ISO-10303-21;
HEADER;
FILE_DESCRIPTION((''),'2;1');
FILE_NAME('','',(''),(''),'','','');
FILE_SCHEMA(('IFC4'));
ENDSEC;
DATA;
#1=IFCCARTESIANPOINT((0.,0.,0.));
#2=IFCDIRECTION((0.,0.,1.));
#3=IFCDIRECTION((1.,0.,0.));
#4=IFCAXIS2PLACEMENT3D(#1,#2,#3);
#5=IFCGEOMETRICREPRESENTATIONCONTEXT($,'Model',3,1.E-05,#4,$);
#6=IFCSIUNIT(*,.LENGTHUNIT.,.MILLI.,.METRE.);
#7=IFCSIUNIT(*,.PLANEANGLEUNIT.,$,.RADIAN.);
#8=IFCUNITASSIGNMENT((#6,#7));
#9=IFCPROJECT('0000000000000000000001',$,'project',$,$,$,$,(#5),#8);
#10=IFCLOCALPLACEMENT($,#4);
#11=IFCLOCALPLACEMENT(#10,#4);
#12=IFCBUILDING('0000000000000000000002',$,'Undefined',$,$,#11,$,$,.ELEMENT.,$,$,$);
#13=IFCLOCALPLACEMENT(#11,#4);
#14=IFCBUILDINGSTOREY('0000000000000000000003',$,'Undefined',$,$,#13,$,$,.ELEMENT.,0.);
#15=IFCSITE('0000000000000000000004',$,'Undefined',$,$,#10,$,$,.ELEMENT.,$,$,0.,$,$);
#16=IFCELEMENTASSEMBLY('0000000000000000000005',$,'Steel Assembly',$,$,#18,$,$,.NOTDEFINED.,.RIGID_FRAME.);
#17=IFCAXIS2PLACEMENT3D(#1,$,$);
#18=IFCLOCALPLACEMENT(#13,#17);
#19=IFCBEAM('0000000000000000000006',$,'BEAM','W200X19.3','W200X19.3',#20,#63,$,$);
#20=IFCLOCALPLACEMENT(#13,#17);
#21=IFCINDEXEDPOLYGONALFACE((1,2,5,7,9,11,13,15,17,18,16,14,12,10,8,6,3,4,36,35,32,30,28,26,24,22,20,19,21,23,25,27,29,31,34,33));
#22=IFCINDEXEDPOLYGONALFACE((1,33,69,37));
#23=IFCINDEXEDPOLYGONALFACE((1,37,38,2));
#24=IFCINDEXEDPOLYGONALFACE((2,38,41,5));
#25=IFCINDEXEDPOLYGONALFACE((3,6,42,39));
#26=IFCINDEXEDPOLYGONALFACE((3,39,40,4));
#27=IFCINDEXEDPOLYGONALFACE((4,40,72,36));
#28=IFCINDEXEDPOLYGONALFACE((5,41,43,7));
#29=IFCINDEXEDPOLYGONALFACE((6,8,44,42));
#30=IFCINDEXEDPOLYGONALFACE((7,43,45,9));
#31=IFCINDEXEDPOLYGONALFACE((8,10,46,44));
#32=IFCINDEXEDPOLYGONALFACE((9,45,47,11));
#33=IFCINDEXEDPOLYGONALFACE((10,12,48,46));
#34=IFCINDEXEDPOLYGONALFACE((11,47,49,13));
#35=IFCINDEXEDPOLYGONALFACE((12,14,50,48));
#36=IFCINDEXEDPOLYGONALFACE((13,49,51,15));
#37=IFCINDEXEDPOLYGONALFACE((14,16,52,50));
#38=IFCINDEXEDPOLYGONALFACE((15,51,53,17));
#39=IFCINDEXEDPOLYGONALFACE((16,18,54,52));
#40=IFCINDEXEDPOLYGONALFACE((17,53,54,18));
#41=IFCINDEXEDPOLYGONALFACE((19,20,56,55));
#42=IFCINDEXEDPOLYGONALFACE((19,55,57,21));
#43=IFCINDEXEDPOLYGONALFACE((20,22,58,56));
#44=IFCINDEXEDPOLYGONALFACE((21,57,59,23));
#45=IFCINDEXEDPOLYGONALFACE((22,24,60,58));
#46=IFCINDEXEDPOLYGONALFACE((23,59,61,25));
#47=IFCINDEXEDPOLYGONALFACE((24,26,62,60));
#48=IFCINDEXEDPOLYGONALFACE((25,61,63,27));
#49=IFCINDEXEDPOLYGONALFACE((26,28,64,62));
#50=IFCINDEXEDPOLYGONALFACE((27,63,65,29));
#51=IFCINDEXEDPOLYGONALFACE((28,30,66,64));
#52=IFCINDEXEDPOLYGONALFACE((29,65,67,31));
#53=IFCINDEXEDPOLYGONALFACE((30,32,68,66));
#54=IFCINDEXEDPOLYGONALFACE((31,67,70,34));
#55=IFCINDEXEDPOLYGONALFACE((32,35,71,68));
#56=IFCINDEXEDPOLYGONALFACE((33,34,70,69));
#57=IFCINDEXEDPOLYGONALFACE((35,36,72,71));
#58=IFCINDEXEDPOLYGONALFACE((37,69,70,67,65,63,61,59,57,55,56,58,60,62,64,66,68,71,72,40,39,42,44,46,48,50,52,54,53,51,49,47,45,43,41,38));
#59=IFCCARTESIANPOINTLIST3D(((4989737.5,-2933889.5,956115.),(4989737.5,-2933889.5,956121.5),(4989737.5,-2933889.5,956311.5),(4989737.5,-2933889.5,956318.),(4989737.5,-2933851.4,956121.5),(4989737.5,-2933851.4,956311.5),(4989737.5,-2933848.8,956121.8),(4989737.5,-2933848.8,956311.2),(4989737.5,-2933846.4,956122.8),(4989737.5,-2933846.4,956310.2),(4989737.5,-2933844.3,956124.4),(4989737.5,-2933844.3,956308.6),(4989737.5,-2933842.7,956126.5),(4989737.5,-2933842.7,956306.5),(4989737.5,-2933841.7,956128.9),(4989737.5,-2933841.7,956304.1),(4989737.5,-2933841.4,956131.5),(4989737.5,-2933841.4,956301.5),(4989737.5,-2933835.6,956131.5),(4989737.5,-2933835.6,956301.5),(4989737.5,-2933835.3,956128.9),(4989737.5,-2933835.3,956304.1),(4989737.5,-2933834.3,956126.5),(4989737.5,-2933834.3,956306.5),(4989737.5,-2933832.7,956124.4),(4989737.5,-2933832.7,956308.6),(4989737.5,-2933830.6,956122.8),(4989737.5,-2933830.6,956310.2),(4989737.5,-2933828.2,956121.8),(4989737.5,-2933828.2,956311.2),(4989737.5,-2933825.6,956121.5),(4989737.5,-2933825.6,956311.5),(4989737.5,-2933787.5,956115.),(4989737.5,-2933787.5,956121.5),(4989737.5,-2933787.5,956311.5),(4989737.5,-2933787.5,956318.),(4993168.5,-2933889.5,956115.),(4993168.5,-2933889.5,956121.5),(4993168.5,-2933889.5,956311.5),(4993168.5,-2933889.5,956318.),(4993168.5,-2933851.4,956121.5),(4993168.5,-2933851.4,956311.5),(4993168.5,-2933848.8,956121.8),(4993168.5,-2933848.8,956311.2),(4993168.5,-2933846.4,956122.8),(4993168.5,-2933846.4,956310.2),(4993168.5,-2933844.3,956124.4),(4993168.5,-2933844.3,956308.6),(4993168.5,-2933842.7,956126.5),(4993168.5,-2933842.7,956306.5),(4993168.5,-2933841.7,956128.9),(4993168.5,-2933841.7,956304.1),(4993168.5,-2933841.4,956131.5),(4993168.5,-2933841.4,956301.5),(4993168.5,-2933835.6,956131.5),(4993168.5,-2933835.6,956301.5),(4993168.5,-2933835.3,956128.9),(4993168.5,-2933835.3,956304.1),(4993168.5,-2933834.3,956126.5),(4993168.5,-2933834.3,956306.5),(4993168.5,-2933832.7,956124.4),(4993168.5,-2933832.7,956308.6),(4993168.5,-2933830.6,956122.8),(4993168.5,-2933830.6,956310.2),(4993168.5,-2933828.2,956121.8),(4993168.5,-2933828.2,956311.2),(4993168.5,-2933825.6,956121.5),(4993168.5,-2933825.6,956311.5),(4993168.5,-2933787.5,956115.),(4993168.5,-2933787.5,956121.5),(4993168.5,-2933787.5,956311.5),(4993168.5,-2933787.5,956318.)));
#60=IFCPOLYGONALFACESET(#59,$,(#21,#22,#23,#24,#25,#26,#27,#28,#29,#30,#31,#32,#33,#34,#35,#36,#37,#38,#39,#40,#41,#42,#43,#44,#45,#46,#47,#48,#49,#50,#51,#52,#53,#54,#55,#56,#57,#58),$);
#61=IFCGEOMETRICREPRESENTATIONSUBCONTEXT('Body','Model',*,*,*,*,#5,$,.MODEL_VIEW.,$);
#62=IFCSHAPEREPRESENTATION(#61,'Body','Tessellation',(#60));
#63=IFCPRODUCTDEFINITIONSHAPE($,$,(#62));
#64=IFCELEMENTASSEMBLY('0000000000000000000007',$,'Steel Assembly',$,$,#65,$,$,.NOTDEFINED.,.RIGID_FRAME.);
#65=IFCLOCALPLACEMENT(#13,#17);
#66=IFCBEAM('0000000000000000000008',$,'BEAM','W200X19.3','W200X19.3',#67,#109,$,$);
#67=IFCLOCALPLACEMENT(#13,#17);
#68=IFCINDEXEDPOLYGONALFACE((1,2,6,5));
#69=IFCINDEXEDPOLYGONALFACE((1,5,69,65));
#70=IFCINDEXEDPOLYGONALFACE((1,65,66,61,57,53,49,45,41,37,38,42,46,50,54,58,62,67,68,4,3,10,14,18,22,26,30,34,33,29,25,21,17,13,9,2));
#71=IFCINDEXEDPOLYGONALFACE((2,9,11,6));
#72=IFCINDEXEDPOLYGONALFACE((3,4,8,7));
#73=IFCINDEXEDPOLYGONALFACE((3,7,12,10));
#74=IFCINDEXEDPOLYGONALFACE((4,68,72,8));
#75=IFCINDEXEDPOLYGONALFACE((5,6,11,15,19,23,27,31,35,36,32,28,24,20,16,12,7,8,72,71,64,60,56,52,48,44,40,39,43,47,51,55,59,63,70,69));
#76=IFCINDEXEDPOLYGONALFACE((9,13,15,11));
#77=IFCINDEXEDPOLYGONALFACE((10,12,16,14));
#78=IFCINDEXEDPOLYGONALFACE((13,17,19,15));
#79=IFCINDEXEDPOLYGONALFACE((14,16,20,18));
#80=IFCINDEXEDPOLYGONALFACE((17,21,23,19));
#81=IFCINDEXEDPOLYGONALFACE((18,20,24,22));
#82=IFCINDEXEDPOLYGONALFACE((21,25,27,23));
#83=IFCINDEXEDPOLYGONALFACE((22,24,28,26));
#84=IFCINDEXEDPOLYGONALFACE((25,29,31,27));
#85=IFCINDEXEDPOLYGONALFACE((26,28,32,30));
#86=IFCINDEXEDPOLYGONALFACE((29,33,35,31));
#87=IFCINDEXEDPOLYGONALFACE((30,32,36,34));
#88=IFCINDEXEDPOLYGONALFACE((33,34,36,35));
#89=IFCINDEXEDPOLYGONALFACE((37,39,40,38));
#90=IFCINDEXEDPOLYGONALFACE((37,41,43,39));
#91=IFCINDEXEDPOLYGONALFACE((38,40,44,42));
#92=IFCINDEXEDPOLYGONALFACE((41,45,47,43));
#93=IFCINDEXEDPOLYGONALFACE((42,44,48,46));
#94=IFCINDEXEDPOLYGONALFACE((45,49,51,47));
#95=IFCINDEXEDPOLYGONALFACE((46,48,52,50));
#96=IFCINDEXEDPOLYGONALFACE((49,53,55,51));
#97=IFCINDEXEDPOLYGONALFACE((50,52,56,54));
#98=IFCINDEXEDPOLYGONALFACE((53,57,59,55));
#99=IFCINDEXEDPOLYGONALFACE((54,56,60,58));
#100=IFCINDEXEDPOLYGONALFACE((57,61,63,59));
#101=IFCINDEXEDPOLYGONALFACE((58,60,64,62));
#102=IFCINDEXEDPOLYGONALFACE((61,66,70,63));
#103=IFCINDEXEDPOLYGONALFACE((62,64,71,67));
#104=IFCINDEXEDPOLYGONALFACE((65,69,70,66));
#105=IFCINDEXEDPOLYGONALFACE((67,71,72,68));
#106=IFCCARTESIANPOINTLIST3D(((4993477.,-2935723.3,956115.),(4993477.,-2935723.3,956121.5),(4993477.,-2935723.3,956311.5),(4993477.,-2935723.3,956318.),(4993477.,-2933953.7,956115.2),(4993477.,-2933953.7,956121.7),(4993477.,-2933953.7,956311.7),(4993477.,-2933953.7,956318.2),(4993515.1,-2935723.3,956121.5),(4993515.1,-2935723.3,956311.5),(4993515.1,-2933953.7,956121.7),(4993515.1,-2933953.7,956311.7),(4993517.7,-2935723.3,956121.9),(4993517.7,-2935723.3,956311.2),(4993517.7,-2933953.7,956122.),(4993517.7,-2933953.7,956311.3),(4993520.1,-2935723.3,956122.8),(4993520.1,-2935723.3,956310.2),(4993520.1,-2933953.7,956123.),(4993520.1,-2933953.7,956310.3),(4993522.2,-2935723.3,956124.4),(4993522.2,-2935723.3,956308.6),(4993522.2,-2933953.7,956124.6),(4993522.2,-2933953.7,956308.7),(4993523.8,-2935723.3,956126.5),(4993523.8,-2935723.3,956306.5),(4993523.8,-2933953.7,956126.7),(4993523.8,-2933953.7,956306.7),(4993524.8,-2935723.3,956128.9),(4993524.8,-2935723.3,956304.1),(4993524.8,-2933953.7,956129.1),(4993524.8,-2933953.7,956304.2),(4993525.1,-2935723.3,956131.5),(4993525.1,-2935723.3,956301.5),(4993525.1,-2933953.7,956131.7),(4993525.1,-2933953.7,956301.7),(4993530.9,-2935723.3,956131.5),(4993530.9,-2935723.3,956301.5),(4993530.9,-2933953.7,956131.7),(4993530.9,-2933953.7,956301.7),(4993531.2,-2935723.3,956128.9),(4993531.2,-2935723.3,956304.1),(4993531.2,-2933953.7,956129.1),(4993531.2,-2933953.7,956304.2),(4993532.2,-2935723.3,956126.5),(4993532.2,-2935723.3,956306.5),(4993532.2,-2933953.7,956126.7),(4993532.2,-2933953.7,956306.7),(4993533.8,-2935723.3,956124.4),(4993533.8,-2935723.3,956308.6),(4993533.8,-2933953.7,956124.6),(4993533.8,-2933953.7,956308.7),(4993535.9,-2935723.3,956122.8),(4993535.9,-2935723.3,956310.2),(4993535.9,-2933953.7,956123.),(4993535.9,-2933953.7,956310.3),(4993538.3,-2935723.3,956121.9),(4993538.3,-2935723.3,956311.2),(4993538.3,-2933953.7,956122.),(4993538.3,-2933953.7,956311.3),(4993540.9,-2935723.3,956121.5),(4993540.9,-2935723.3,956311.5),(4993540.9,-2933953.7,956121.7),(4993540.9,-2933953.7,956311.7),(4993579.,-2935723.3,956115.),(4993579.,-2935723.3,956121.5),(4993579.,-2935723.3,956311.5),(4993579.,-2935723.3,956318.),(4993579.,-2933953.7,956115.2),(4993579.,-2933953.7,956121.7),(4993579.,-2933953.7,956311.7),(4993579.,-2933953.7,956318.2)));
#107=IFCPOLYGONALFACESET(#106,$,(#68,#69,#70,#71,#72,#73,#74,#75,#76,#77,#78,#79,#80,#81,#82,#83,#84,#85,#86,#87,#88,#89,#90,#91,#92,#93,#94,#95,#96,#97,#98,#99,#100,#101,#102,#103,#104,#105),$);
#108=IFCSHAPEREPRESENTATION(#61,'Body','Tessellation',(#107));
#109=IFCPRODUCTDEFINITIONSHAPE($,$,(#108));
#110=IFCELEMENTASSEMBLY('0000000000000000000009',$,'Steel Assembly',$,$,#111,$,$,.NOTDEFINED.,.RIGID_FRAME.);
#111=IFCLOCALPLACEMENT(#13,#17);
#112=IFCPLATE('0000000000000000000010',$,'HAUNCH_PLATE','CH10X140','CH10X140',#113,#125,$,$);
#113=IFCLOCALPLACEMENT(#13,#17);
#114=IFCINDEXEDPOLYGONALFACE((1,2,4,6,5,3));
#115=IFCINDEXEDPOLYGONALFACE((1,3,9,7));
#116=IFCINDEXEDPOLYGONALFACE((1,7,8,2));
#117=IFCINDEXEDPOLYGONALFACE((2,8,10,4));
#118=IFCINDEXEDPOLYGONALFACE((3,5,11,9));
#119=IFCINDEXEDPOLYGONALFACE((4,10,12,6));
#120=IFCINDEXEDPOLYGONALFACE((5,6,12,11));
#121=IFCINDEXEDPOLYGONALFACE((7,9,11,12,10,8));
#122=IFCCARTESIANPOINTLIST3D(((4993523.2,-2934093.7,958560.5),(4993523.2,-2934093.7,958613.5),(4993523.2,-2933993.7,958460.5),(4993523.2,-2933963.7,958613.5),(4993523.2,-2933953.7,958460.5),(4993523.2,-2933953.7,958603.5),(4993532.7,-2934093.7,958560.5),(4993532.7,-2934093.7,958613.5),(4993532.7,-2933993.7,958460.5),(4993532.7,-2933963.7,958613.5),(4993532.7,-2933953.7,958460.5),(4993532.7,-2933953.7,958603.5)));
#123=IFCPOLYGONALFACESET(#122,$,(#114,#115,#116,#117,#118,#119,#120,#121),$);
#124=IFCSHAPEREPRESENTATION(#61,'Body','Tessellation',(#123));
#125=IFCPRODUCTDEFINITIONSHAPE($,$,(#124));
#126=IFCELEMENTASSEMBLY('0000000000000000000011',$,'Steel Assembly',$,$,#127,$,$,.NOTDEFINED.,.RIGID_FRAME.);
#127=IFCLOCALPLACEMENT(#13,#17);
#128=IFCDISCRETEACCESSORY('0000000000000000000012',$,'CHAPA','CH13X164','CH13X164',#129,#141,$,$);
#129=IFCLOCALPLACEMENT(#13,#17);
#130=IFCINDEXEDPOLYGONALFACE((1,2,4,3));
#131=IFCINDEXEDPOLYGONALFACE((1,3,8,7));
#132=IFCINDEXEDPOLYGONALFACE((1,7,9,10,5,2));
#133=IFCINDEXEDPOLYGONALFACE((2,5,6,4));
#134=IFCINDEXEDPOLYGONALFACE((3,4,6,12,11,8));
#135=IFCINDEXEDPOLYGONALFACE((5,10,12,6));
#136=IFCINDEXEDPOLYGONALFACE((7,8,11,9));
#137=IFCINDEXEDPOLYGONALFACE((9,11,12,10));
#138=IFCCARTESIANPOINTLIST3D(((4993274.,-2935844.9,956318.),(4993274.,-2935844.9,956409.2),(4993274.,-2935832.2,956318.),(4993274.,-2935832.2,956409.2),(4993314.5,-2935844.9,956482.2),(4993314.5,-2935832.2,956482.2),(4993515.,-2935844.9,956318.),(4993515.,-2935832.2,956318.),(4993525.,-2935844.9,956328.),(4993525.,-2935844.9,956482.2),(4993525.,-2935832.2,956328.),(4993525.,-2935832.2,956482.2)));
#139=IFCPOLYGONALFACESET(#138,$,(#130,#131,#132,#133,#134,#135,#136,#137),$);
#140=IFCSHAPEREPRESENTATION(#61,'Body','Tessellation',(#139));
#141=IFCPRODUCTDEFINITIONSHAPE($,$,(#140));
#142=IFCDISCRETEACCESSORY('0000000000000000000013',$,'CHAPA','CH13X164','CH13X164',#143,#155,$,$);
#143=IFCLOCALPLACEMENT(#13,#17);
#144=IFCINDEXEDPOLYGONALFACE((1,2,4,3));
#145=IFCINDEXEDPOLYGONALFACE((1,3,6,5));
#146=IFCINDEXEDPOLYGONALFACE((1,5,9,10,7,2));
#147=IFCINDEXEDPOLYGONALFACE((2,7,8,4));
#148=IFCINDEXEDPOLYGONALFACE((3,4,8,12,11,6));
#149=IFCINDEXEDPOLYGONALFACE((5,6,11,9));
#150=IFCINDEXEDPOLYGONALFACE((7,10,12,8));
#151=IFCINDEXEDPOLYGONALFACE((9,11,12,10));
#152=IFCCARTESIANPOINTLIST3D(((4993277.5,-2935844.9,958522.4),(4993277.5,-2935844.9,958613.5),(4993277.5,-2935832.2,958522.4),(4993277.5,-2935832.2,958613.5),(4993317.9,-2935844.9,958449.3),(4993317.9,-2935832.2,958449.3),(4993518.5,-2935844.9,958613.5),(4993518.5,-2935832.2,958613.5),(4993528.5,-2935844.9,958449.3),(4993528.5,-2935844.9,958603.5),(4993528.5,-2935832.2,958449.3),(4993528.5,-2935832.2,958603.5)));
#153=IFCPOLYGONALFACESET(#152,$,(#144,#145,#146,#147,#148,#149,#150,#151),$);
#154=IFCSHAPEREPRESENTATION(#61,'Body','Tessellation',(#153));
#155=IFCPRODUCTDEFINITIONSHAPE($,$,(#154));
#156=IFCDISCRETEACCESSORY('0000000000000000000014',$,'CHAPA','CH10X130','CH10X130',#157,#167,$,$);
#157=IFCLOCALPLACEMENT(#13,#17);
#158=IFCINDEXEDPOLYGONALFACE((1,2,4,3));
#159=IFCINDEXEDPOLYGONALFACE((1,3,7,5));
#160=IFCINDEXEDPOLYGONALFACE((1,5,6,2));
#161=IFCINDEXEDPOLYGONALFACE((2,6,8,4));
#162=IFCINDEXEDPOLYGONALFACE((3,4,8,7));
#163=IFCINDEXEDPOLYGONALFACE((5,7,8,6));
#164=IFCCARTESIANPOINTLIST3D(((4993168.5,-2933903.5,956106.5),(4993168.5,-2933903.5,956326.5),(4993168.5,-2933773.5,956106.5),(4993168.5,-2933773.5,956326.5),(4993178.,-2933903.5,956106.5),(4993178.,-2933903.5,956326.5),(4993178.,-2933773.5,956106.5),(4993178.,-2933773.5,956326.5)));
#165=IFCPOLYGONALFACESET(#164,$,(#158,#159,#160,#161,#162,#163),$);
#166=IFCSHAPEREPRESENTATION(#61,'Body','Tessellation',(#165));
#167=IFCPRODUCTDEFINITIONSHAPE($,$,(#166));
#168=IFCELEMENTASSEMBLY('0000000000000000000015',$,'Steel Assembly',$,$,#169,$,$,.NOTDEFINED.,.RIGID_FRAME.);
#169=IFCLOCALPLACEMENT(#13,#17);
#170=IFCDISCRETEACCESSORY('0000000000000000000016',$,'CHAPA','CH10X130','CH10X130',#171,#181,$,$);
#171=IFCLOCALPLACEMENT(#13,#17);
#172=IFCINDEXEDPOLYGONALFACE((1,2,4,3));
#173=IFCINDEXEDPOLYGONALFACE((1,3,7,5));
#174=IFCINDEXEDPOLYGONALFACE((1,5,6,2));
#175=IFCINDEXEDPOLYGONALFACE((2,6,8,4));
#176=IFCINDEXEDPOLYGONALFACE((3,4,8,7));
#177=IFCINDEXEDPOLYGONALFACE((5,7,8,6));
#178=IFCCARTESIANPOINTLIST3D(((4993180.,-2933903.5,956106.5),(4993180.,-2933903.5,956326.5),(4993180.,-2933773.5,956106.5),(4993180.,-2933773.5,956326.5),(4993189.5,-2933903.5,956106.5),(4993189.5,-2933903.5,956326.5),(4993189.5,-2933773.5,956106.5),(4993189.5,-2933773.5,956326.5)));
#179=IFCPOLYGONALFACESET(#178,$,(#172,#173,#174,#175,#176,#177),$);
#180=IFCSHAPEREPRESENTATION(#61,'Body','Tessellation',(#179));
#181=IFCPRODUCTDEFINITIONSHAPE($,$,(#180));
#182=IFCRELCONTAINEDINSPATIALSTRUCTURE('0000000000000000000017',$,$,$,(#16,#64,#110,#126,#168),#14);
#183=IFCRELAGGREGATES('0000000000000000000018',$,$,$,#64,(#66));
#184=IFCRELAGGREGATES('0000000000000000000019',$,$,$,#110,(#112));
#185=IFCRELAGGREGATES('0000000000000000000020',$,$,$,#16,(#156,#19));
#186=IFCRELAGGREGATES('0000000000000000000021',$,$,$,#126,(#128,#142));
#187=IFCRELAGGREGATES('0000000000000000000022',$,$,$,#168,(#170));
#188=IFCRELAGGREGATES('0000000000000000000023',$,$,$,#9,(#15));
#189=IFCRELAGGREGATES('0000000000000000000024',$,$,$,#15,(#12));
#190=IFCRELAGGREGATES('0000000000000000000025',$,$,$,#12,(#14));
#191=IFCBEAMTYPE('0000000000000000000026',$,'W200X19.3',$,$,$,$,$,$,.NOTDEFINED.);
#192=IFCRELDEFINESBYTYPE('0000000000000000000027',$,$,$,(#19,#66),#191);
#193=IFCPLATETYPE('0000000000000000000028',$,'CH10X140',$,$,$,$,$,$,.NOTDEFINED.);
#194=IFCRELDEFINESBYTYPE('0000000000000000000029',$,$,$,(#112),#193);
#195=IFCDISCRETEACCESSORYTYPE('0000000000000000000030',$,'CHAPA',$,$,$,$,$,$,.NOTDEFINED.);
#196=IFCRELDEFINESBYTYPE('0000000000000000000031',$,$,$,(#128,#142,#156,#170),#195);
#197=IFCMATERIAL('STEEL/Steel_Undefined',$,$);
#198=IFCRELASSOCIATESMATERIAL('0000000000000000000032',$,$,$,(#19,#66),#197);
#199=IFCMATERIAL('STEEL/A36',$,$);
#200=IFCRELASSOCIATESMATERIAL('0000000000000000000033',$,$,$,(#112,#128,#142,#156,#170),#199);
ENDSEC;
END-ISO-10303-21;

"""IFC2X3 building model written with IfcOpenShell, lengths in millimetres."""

from ifc_helpers import new_model, si_unit, frame, origin_with_axes, origin_2d_with_axis, place, context, subcontext, project, spatial, polyline, i_section, outline, extrude, clip, halfspace, material, type_object, element, aggregate, save


model = new_model("IFC2X3")

# Units and contexts
model_context = context("Model", 3, precision=1e-05, world=origin_with_axes())
body_context = subcontext(model_context, "Body", "Model", "MODEL_VIEW")
ifc_project = project(units=[si_unit("LENGTHUNIT", "METRE", prefix="MILLI"), si_unit("PLANEANGLEUNIT", "RADIAN")], contexts=[model_context])

# Site, building, storey
site_placement = place(None, origin_with_axes())
site = spatial("IfcSite", under=ifc_project, at=site_placement, Name="Undefined", CompositionType="ELEMENT", RefElevation=0.0)
building_placement = place(site_placement, origin_with_axes())
building = spatial("IfcBuilding", under=site, at=building_placement, Name="Undefined", CompositionType="ELEMENT")
storey_placement = place(building_placement, origin_with_axes())
storey = spatial("IfcBuildingStorey", under=building, at=storey_placement, Name="Undefined", CompositionType="ELEMENT", Elevation=0.0)

# Shared definitions
ifc_material_1 = material(Name="STEEL/Steel_Undefined")

# Element assemblies, beams
assembly_1_placement = place(storey_placement, origin_with_axes())
assembly_1 = element("IfcElementAssembly", 1, at=assembly_1_placement, inside=storey, Name="Steel Assembly", AssemblyPlace="NOTDEFINED", PredefinedType="RIGID_FRAME")
beam_type = type_object("IfcBeamType", Name="W200X19.3", PredefinedType="NOTDEFINED")
beam_1_placement = place(assembly_1_placement, frame((4993179.0, -2933838.5, 956216.5), z_axis=(0.0, 0.0, -1.0), x_axis=(-1.0, 0.0, 0.0)))
beam_1 = element("IfcBeam", 2, at=beam_1_placement, type_object=beam_type, material=ifc_material_1, Name="BEAM", Description="W200X19.3", ObjectType="W200X19.3", context=body_context, shape_type="Clipping", body=[
    clip(clip(extrude(i_section(OverallWidth=102.0, OverallDepth=203.0, WebThickness=5.8, FlangeThickness=6.5, FilletRadius=10.0, at=origin_2d_with_axis()), frame((3441.5, 0.0, 0.0), z_axis=(-1.0, 0.0, 0.0), x_axis=(0.0, -1.0, 0.0)), (0.0, 0.0, 1.0), 3431.0), halfspace(frame((3441.5, 0.0, -101.5), z_axis=(-1.0, 0.0, 0.0), x_axis=(0.0, 1.0, 0.0)), True)), halfspace(frame((10.5, 0.0, -101.5), z_axis=(1.0, 0.0, 0.0), x_axis=(0.0, -1.0, 0.0)), True)),
])
assembly_2_placement = place(storey_placement, origin_with_axes())
assembly_2 = element("IfcElementAssembly", 3, at=assembly_2_placement, inside=storey, Name="Steel Assembly", AssemblyPlace="NOTDEFINED", PredefinedType="RIGID_FRAME")
beam_2_placement = place(assembly_2_placement, frame((4993528.0, -2933838.5, 956216.7), z_axis=(0.0, 0.000084, -1.0), x_axis=(0.0, -1.0, -0.000084)))
beam_2 = element("IfcBeam", 4, at=beam_2_placement, type_object=beam_type, material=ifc_material_1, Name="BEAM", Description="W200X19.3", ObjectType="W200X19.3", context=body_context, shape_type="Clipping", body=[
    clip(clip(clip(clip(extrude(i_section(OverallWidth=102.0, OverallDepth=203.0, WebThickness=5.8, FlangeThickness=6.5, FilletRadius=10.0, at=origin_2d_with_axis()), frame((1884.8, 0.0, 0.0), z_axis=(-1.0, 0.0, 0.0), x_axis=(0.0, -1.0, 0.0)), (0.0, 0.0, 1.0), 1769.6), halfspace(frame((113.2, -51.0, 101.7), z_axis=(-1.0, 0.0, 0.000084), x_axis=(-0.000084, 0.0, -1.0)), False)), halfspace(frame((1886.8, 51.0, 104.5), z_axis=(1.0, 0.0, -0.000084), x_axis=(-0.000084, 0.0, -1.0)), False)), halfspace(frame((1884.8, 0.0, 101.5), z_axis=(-1.0, 0.0, 0.000084), x_axis=(0.0, -1.0, 0.0)), True)), halfspace(frame((115.2, 0.0, 101.5), z_axis=(1.0, 0.0, -0.000084), x_axis=(0.0, 1.0, 0.0)), True)),
])
aggregate(assembly_2, [beam_2])

# Element assembly, plate
assembly_3_placement = place(storey_placement, origin_with_axes())
assembly_3 = element("IfcElementAssembly", 5, at=assembly_3_placement, inside=storey, Name="Steel Assembly", AssemblyPlace="NOTDEFINED", PredefinedType="RIGID_FRAME")
ifc_material_2 = material(Name="STEEL/A36")
plate_type = type_object("IfcPlateType", Name="CH10X140", PredefinedType="NOTDEFINED")
plate_placement = place(assembly_3_placement, frame((4993528.0, -2933953.7, 958613.5), z_axis=(-1.0, 0.0, 0.0), x_axis=(0.0, 0.0, -1.0)))
plate = element("IfcPlate", 6, at=plate_placement, type_object=plate_type, material=ifc_material_2, Name="HAUNCH_PLATE", Description="CH10X140", ObjectType="CH10X140", context=body_context, shape_type="SweptSolid", body=[
    extrude(outline(polyline([(0.0, 10.0), (10.0, 0.0), (153.0, 0.0), (153.0, 40.0), (53.0, 140.0), (0.0, 140.0), (0.0, 10.0)])), frame((0.0, 0.0, -4.8), z_axis=(0.0, 0.0, 1.0), x_axis=(1.0, 0.0, 0.0)), (0.0, 0.0, 1.0), 9.5),
])
aggregate(assembly_3, [plate])

# Element assembly, discrete accessories
assembly_4_placement = place(storey_placement, origin_with_axes())
assembly_4 = element("IfcElementAssembly", 7, at=assembly_4_placement, inside=storey, Name="Steel Assembly", AssemblyPlace="NOTDEFINED", PredefinedType="RIGID_FRAME")
discrete_accessory_type_1 = type_object("IfcDiscreteAccessoryType", Name="CHAPA")
discrete_accessory_1_placement = place(assembly_4_placement, frame((4993525.0, -2935838.5, 956318.0), z_axis=(0.0, 1.0, 0.0), x_axis=(-1.0, 0.0, 0.0)))
discrete_accessory_1 = element("IfcDiscreteAccessory", 8, at=discrete_accessory_1_placement, type_object=discrete_accessory_type_1, material=ifc_material_2, Name="CHAPA", Description="CH13X164", ObjectType="CH13X164", context=body_context, shape_type="SweptSolid", body=[
    extrude(outline(polyline([(0.0, 10.0), (10.0, 0.0), (251.0, 0.0), (251.0, 91.2), (210.5, 164.2), (0.0, 164.2), (0.0, 10.0)])), frame((0.0, 0.0, -6.3), z_axis=(0.0, 0.0, 1.0), x_axis=(1.0, 0.0, 0.0)), (0.0, 0.0, 1.0), 12.7),
])
discrete_accessory_2_placement = place(assembly_4_placement, frame((4993277.5, -2935838.5, 958613.5), z_axis=(0.0, 1.0, 0.0), x_axis=(1.0, 0.0, 0.0)))
discrete_accessory_2 = element("IfcDiscreteAccessory", 9, at=discrete_accessory_2_placement, type_object=discrete_accessory_type_1, material=ifc_material_2, Name="CHAPA", Description="CH13X164", ObjectType="CH13X164", context=body_context, shape_type="SweptSolid", body=[
    extrude(outline(polyline([(0.0, 0.0), (241.0, 0.0), (251.0, 10.0), (251.0, 164.2), (40.4, 164.2), (0.0, 91.1), (0.0, 0.0)])), frame((0.0, 0.0, -6.3), z_axis=(0.0, 0.0, 1.0), x_axis=(1.0, 0.0, 0.0)), (0.0, 0.0, 1.0), 12.7),
])

# Discrete accessory
discrete_accessory_3_placement = place(assembly_1_placement, frame((4993173.2, -2933838.5, 956326.5), z_axis=(-1.0, 0.0, 0.0), x_axis=(0.0, 0.0, -1.0)))
discrete_accessory_3 = element("IfcDiscreteAccessory", 10, at=discrete_accessory_3_placement, type_object=discrete_accessory_type_1, material=ifc_material_2, Name="CHAPA", Description="CH10X130", ObjectType="CH10X130", context=body_context, shape_type="SweptSolid", body=[
    extrude(outline(polyline([(220.0, 65.0), (220.0, -65.0), (0.0, -65.0), (0.0, 65.0), (220.0, 65.0)])), frame((0.0, 0.0, -4.8), z_axis=(0.0, 0.0, 1.0), x_axis=(1.0, 0.0, 0.0)), (0.0, 0.0, 1.0), 9.5),
])
aggregate(assembly_1, [discrete_accessory_3, beam_1])

# Element assembly, discrete accessory
assembly_5_placement = place(storey_placement, origin_with_axes())
assembly_5 = element("IfcElementAssembly", 11, at=assembly_5_placement, inside=storey, Name="Steel Assembly", AssemblyPlace="NOTDEFINED", PredefinedType="RIGID_FRAME")
discrete_accessory_4_placement = place(assembly_5_placement, frame((4993184.7, -2933838.5, 956326.5), z_axis=(-1.0, 0.0, 0.0), x_axis=(0.0, 0.0, -1.0)))
discrete_accessory_4 = element("IfcDiscreteAccessory", 12, at=discrete_accessory_4_placement, type_object=discrete_accessory_type_1, material=ifc_material_2, Name="CHAPA", Description="CH10X130", ObjectType="CH10X130", context=body_context, shape_type="SweptSolid", body=[
    extrude(outline(polyline([(220.0, 65.0), (220.0, -65.0), (0.0, -65.0), (0.0, 65.0), (220.0, 65.0)])), frame((0.0, 0.0, -4.8), z_axis=(0.0, 0.0, 1.0), x_axis=(1.0, 0.0, 0.0)), (0.0, 0.0, 1.0), 9.5),
])

aggregate(assembly_4, [discrete_accessory_1, discrete_accessory_2])

aggregate(assembly_5, [discrete_accessory_4])

save(model, "model.ifc")
